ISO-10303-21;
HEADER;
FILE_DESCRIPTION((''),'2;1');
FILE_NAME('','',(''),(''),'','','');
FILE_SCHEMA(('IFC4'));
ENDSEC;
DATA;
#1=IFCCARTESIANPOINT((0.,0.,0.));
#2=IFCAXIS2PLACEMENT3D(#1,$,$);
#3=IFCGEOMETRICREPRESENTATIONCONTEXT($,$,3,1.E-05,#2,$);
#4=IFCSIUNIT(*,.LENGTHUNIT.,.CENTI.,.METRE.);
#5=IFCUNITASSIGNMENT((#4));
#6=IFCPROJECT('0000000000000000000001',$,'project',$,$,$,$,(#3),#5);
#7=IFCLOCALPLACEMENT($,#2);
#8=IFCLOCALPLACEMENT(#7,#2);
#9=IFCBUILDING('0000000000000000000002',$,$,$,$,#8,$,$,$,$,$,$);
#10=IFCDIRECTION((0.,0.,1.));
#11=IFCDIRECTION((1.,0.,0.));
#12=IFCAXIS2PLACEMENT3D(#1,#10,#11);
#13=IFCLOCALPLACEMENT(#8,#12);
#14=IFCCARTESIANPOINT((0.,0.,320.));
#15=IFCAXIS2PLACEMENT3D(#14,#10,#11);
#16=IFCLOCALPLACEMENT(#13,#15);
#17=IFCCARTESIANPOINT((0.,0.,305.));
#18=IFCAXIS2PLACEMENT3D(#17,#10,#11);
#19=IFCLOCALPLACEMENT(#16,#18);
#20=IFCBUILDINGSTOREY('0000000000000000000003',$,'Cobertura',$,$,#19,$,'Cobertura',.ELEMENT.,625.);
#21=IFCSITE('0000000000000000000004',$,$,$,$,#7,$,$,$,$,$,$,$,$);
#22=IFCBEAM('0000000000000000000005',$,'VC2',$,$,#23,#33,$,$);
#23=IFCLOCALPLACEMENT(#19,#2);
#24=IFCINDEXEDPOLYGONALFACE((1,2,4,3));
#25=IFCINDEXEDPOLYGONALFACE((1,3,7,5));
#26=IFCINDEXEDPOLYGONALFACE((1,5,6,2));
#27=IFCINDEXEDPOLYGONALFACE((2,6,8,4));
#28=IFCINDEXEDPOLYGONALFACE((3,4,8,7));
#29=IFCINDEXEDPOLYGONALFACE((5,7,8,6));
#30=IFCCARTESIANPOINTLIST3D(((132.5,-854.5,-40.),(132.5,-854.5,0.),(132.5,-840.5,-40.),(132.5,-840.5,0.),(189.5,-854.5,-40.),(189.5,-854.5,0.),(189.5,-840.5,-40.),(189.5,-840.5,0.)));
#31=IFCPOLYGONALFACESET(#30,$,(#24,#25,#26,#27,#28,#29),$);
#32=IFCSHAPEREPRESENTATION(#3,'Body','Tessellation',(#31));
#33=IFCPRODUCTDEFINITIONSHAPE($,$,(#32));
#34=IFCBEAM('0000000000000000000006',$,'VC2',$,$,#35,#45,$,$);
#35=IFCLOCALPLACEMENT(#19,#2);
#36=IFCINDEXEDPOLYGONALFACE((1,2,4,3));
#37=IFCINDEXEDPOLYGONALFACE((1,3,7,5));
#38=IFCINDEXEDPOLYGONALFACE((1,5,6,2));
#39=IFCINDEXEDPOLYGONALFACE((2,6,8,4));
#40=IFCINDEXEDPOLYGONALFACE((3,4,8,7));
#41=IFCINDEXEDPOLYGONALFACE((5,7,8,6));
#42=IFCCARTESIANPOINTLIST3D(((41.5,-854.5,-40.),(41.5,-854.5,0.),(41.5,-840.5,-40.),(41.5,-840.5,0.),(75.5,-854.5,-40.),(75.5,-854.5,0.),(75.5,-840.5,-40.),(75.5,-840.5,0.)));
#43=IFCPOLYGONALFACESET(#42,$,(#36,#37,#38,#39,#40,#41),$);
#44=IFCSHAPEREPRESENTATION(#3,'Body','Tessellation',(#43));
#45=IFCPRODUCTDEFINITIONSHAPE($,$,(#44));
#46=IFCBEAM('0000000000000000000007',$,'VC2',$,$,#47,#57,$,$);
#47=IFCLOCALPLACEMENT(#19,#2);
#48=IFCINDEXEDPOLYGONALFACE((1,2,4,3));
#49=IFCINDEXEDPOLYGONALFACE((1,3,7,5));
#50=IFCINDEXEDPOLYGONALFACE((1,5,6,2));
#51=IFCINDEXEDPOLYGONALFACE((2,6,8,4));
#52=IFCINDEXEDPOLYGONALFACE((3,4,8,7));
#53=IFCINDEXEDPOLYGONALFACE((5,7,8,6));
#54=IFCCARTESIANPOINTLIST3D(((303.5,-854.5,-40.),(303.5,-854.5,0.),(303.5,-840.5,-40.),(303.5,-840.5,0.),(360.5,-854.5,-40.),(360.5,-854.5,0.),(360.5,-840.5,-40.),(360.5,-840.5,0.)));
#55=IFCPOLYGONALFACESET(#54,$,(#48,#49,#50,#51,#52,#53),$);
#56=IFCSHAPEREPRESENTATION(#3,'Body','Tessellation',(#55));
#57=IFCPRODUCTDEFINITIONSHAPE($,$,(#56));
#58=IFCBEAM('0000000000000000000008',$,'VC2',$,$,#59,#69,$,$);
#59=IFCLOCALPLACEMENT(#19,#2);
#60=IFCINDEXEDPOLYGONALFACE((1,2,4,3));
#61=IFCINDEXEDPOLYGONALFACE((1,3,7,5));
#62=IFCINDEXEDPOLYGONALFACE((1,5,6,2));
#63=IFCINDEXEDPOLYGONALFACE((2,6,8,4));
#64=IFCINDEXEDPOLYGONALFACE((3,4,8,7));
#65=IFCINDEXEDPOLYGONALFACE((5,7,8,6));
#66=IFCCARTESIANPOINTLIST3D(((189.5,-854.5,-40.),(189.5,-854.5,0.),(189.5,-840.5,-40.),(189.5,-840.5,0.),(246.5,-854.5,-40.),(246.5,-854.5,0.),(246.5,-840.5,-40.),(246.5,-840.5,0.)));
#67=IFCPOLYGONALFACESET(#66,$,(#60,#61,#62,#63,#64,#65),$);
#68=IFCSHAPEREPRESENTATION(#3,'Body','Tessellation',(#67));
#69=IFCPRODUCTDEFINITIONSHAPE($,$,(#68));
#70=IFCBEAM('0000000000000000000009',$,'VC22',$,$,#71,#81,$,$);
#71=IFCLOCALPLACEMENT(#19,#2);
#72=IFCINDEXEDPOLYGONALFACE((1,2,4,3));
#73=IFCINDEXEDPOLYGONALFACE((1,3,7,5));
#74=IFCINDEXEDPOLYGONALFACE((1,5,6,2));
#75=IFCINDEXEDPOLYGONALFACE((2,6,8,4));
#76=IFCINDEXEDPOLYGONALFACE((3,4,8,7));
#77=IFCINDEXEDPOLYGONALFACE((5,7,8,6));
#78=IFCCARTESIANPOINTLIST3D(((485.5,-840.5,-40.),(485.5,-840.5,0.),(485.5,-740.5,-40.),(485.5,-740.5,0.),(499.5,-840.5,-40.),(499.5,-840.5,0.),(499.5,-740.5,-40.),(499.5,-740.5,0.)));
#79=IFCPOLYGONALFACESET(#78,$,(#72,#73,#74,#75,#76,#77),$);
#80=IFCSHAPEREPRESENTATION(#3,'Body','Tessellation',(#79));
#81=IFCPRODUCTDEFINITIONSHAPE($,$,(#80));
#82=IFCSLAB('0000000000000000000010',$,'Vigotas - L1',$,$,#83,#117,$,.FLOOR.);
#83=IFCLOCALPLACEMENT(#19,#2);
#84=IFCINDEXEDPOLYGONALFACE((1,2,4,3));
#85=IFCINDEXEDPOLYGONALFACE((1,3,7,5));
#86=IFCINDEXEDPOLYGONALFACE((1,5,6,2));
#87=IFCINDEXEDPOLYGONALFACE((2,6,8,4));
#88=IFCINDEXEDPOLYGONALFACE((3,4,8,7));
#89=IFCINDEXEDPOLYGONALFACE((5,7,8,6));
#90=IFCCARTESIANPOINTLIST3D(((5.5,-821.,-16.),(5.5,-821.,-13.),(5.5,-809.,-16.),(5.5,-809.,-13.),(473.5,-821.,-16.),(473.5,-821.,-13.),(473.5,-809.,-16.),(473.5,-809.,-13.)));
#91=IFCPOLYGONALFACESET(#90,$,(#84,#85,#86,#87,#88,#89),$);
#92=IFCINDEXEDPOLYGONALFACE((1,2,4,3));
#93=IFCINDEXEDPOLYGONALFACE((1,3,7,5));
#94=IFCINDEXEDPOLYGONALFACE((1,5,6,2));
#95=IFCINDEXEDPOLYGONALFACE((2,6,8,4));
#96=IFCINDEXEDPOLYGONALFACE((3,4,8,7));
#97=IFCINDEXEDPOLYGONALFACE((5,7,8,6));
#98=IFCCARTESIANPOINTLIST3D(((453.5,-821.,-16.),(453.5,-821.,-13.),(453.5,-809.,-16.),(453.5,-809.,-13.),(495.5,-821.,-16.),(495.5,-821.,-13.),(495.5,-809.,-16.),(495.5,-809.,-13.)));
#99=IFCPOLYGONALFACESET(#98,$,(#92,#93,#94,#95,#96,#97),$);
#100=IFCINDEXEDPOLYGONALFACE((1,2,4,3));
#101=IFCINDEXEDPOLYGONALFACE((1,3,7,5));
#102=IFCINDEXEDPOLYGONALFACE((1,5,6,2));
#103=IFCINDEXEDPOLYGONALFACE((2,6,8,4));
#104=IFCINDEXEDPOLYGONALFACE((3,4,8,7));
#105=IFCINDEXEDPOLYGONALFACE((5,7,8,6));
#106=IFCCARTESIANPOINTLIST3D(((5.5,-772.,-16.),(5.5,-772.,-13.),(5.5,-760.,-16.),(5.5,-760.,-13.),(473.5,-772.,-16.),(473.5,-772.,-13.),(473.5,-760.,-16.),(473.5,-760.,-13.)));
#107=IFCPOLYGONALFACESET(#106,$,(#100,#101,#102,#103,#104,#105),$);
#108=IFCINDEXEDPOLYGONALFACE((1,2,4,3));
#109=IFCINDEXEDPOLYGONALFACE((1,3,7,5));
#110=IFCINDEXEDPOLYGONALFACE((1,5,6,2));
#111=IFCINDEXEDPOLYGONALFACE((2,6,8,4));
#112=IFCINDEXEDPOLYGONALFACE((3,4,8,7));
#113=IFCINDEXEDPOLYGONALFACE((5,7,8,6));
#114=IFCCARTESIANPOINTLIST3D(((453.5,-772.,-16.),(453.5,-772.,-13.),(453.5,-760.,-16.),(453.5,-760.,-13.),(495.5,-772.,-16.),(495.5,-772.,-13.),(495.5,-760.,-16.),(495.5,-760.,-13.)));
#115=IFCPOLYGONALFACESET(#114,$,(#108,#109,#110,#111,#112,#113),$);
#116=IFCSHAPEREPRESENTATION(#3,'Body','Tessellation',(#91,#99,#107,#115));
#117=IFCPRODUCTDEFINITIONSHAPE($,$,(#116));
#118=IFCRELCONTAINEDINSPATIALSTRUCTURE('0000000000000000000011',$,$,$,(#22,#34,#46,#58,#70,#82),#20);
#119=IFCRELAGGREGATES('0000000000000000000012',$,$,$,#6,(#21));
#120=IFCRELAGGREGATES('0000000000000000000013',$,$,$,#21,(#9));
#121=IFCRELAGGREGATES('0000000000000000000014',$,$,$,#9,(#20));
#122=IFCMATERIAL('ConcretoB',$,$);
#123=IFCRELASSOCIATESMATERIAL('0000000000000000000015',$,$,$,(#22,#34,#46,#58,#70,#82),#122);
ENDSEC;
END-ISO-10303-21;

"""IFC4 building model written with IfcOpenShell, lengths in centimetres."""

from ifc_helpers import new_model, si_unit, frame, origin, origin_with_axes, place, context, project, spatial, polyline, outline, extrude, material, element, save


model = new_model("IFC4")

# Units and contexts
context_of_model = context(None, 3, precision=1e-05, world=origin())
ifc_project = project(units=[si_unit("LENGTHUNIT", "METRE", prefix="CENTI")], contexts=[context_of_model])

# Site, building, storey
site_placement = place(None, origin())
site = spatial("IfcSite", under=ifc_project, at=site_placement)
building_placement = place(site_placement, origin())
building = spatial("IfcBuilding", under=site, at=building_placement)
placement_1 = place(building_placement, origin_with_axes())
placement_2 = place(placement_1, frame((0.0, 0.0, 320.0), z_axis=(0.0, 0.0, 1.0), x_axis=(1.0, 0.0, 0.0)))
storey_placement = place(placement_2, frame((0.0, 0.0, 305.0), z_axis=(0.0, 0.0, 1.0), x_axis=(1.0, 0.0, 0.0)))
storey = spatial("IfcBuildingStorey", under=building, at=storey_placement, Name="Cobertura", LongName="Cobertura", CompositionType="ELEMENT", Elevation=625.0)

# Shared definitions
ifc_material_1 = material(Name="ConcretoB")

# Beams
beam_1_placement = place(storey_placement, frame((161.0, -847.5, 0.0), z_axis=(0.0, 0.0, 1.0), x_axis=(1.0, 0.0, 0.0)))
element("IfcBeam", 1, at=beam_1_placement, inside=storey, material=ifc_material_1, Name="VC2", context=context_of_model, shape_type="SolidModel", body=[
    extrude(outline(polyline([(-7.0, -20.0), (7.0, -20.0), (7.0, 20.0), (-7.0, 20.0), (-7.0, -20.0)])), frame((-28.5, 0.0, -20.0), z_axis=(1.0, 0.0, 0.0), x_axis=(0.0, -1.0, 0.0)), (0.0, 0.0, 1.0), 57.0),
])
beam_2_placement = place(storey_placement, frame((58.5, -847.5, 0.0), z_axis=(0.0, 0.0, 1.0), x_axis=(1.0, 0.0, 0.0)))
element("IfcBeam", 2, at=beam_2_placement, inside=storey, material=ifc_material_1, Name="VC2", context=context_of_model, shape_type="SolidModel", body=[
    extrude(outline(polyline([(-7.0, -20.0), (7.0, -20.0), (7.0, 20.0), (-7.0, 20.0), (-7.0, -20.0)])), frame((-17.0, 0.0, -20.0), z_axis=(1.0, 0.0, 0.0), x_axis=(0.0, -1.0, 0.0)), (0.0, 0.0, 1.0), 34.0),
])
for number, where, z_axis, x_axis, name in (
    (3, (332.0, -847.5, 0.0), (0.0, 0.0, 1.0), (1.0, 0.0, 0.0), "VC2"),
    (4, (218.0, -847.5, 0.0), (0.0, 0.0, 1.0), (1.0, 0.0, 0.0), "VC2"),
):
    element("IfcBeam", number, at=place(storey_placement, frame(where, z_axis=z_axis, x_axis=x_axis)), inside=storey, material=ifc_material_1, Name=name, context=context_of_model, shape_type="SolidModel", body=[
        extrude(outline(polyline([(-7.0, -20.0), (7.0, -20.0), (7.0, 20.0), (-7.0, 20.0), (-7.0, -20.0)])), frame((-28.5, 0.0, -20.0), z_axis=(1.0, 0.0, 0.0), x_axis=(0.0, -1.0, 0.0)), (0.0, 0.0, 1.0), 57.0),
    ])
beam_3_placement = place(storey_placement, frame((492.5, -790.5, 0.0), z_axis=(0.0, 0.0, 1.0), x_axis=(1.0, 0.0, 0.0)))
element("IfcBeam", 5, at=beam_3_placement, inside=storey, material=ifc_material_1, Name="VC22", context=context_of_model, shape_type="SolidModel", body=[
    extrude(outline(polyline([(-7.0, -20.0), (7.0, -20.0), (7.0, 20.0), (-7.0, 20.0), (-7.0, -20.0)])), frame((0.0, -50.0, -20.0), z_axis=(0.0, 1.0, 0.0), x_axis=(1.0, 0.0, 0.0)), (0.0, 0.0, 1.0), 100.0),
])

# Slab
slab_placement = place(storey_placement, frame((250.5, -790.5, -13.0), z_axis=(0.0, 0.0, 1.0), x_axis=(1.0, 0.0, 0.0)))
element("IfcSlab", 6, at=slab_placement, inside=storey, material=ifc_material_1, Name="Vigotas - L1", PredefinedType="FLOOR", context=context_of_model, shape_type="SolidModel", body=[
    extrude(outline(polyline([(6.0, 1.5), (-6.0, 1.5), (-6.0, -1.5), (6.0, -1.5), (6.0, 1.5), (6.0, 1.5)])), frame((-245.0, -24.5, -1.5), z_axis=(1.0, 0.0, 0.0), x_axis=(0.0, -1.0, 0.0)), (0.0, 0.0, 1.0), 468.0),
    extrude(outline(polyline([(6.0, 1.5), (-6.0, 1.5), (-6.0, -1.5), (6.0, -1.5), (6.0, 1.5), (6.0, 1.5)])), frame((203.0, -24.5, -1.5), z_axis=(1.0, 0.0, 0.0), x_axis=(0.0, -1.0, 0.0)), (0.0, 0.0, 1.0), 42.0),
    extrude(outline(polyline([(6.0, 1.5), (-6.0, 1.5), (-6.0, -1.5), (6.0, -1.5), (6.0, 1.5), (6.0, 1.5)])), frame((-245.0, 24.5, -1.5), z_axis=(1.0, 0.0, 0.0), x_axis=(0.0, -1.0, 0.0)), (0.0, 0.0, 1.0), 468.0),
    extrude(outline(polyline([(6.0, 1.5), (-6.0, 1.5), (-6.0, -1.5), (6.0, -1.5), (6.0, 1.5), (6.0, 1.5)])), frame((203.0, 24.5, -1.5), z_axis=(1.0, 0.0, 0.0), x_axis=(0.0, -1.0, 0.0)), (0.0, 0.0, 1.0), 42.0),
])

save(model, "model.ifc")
